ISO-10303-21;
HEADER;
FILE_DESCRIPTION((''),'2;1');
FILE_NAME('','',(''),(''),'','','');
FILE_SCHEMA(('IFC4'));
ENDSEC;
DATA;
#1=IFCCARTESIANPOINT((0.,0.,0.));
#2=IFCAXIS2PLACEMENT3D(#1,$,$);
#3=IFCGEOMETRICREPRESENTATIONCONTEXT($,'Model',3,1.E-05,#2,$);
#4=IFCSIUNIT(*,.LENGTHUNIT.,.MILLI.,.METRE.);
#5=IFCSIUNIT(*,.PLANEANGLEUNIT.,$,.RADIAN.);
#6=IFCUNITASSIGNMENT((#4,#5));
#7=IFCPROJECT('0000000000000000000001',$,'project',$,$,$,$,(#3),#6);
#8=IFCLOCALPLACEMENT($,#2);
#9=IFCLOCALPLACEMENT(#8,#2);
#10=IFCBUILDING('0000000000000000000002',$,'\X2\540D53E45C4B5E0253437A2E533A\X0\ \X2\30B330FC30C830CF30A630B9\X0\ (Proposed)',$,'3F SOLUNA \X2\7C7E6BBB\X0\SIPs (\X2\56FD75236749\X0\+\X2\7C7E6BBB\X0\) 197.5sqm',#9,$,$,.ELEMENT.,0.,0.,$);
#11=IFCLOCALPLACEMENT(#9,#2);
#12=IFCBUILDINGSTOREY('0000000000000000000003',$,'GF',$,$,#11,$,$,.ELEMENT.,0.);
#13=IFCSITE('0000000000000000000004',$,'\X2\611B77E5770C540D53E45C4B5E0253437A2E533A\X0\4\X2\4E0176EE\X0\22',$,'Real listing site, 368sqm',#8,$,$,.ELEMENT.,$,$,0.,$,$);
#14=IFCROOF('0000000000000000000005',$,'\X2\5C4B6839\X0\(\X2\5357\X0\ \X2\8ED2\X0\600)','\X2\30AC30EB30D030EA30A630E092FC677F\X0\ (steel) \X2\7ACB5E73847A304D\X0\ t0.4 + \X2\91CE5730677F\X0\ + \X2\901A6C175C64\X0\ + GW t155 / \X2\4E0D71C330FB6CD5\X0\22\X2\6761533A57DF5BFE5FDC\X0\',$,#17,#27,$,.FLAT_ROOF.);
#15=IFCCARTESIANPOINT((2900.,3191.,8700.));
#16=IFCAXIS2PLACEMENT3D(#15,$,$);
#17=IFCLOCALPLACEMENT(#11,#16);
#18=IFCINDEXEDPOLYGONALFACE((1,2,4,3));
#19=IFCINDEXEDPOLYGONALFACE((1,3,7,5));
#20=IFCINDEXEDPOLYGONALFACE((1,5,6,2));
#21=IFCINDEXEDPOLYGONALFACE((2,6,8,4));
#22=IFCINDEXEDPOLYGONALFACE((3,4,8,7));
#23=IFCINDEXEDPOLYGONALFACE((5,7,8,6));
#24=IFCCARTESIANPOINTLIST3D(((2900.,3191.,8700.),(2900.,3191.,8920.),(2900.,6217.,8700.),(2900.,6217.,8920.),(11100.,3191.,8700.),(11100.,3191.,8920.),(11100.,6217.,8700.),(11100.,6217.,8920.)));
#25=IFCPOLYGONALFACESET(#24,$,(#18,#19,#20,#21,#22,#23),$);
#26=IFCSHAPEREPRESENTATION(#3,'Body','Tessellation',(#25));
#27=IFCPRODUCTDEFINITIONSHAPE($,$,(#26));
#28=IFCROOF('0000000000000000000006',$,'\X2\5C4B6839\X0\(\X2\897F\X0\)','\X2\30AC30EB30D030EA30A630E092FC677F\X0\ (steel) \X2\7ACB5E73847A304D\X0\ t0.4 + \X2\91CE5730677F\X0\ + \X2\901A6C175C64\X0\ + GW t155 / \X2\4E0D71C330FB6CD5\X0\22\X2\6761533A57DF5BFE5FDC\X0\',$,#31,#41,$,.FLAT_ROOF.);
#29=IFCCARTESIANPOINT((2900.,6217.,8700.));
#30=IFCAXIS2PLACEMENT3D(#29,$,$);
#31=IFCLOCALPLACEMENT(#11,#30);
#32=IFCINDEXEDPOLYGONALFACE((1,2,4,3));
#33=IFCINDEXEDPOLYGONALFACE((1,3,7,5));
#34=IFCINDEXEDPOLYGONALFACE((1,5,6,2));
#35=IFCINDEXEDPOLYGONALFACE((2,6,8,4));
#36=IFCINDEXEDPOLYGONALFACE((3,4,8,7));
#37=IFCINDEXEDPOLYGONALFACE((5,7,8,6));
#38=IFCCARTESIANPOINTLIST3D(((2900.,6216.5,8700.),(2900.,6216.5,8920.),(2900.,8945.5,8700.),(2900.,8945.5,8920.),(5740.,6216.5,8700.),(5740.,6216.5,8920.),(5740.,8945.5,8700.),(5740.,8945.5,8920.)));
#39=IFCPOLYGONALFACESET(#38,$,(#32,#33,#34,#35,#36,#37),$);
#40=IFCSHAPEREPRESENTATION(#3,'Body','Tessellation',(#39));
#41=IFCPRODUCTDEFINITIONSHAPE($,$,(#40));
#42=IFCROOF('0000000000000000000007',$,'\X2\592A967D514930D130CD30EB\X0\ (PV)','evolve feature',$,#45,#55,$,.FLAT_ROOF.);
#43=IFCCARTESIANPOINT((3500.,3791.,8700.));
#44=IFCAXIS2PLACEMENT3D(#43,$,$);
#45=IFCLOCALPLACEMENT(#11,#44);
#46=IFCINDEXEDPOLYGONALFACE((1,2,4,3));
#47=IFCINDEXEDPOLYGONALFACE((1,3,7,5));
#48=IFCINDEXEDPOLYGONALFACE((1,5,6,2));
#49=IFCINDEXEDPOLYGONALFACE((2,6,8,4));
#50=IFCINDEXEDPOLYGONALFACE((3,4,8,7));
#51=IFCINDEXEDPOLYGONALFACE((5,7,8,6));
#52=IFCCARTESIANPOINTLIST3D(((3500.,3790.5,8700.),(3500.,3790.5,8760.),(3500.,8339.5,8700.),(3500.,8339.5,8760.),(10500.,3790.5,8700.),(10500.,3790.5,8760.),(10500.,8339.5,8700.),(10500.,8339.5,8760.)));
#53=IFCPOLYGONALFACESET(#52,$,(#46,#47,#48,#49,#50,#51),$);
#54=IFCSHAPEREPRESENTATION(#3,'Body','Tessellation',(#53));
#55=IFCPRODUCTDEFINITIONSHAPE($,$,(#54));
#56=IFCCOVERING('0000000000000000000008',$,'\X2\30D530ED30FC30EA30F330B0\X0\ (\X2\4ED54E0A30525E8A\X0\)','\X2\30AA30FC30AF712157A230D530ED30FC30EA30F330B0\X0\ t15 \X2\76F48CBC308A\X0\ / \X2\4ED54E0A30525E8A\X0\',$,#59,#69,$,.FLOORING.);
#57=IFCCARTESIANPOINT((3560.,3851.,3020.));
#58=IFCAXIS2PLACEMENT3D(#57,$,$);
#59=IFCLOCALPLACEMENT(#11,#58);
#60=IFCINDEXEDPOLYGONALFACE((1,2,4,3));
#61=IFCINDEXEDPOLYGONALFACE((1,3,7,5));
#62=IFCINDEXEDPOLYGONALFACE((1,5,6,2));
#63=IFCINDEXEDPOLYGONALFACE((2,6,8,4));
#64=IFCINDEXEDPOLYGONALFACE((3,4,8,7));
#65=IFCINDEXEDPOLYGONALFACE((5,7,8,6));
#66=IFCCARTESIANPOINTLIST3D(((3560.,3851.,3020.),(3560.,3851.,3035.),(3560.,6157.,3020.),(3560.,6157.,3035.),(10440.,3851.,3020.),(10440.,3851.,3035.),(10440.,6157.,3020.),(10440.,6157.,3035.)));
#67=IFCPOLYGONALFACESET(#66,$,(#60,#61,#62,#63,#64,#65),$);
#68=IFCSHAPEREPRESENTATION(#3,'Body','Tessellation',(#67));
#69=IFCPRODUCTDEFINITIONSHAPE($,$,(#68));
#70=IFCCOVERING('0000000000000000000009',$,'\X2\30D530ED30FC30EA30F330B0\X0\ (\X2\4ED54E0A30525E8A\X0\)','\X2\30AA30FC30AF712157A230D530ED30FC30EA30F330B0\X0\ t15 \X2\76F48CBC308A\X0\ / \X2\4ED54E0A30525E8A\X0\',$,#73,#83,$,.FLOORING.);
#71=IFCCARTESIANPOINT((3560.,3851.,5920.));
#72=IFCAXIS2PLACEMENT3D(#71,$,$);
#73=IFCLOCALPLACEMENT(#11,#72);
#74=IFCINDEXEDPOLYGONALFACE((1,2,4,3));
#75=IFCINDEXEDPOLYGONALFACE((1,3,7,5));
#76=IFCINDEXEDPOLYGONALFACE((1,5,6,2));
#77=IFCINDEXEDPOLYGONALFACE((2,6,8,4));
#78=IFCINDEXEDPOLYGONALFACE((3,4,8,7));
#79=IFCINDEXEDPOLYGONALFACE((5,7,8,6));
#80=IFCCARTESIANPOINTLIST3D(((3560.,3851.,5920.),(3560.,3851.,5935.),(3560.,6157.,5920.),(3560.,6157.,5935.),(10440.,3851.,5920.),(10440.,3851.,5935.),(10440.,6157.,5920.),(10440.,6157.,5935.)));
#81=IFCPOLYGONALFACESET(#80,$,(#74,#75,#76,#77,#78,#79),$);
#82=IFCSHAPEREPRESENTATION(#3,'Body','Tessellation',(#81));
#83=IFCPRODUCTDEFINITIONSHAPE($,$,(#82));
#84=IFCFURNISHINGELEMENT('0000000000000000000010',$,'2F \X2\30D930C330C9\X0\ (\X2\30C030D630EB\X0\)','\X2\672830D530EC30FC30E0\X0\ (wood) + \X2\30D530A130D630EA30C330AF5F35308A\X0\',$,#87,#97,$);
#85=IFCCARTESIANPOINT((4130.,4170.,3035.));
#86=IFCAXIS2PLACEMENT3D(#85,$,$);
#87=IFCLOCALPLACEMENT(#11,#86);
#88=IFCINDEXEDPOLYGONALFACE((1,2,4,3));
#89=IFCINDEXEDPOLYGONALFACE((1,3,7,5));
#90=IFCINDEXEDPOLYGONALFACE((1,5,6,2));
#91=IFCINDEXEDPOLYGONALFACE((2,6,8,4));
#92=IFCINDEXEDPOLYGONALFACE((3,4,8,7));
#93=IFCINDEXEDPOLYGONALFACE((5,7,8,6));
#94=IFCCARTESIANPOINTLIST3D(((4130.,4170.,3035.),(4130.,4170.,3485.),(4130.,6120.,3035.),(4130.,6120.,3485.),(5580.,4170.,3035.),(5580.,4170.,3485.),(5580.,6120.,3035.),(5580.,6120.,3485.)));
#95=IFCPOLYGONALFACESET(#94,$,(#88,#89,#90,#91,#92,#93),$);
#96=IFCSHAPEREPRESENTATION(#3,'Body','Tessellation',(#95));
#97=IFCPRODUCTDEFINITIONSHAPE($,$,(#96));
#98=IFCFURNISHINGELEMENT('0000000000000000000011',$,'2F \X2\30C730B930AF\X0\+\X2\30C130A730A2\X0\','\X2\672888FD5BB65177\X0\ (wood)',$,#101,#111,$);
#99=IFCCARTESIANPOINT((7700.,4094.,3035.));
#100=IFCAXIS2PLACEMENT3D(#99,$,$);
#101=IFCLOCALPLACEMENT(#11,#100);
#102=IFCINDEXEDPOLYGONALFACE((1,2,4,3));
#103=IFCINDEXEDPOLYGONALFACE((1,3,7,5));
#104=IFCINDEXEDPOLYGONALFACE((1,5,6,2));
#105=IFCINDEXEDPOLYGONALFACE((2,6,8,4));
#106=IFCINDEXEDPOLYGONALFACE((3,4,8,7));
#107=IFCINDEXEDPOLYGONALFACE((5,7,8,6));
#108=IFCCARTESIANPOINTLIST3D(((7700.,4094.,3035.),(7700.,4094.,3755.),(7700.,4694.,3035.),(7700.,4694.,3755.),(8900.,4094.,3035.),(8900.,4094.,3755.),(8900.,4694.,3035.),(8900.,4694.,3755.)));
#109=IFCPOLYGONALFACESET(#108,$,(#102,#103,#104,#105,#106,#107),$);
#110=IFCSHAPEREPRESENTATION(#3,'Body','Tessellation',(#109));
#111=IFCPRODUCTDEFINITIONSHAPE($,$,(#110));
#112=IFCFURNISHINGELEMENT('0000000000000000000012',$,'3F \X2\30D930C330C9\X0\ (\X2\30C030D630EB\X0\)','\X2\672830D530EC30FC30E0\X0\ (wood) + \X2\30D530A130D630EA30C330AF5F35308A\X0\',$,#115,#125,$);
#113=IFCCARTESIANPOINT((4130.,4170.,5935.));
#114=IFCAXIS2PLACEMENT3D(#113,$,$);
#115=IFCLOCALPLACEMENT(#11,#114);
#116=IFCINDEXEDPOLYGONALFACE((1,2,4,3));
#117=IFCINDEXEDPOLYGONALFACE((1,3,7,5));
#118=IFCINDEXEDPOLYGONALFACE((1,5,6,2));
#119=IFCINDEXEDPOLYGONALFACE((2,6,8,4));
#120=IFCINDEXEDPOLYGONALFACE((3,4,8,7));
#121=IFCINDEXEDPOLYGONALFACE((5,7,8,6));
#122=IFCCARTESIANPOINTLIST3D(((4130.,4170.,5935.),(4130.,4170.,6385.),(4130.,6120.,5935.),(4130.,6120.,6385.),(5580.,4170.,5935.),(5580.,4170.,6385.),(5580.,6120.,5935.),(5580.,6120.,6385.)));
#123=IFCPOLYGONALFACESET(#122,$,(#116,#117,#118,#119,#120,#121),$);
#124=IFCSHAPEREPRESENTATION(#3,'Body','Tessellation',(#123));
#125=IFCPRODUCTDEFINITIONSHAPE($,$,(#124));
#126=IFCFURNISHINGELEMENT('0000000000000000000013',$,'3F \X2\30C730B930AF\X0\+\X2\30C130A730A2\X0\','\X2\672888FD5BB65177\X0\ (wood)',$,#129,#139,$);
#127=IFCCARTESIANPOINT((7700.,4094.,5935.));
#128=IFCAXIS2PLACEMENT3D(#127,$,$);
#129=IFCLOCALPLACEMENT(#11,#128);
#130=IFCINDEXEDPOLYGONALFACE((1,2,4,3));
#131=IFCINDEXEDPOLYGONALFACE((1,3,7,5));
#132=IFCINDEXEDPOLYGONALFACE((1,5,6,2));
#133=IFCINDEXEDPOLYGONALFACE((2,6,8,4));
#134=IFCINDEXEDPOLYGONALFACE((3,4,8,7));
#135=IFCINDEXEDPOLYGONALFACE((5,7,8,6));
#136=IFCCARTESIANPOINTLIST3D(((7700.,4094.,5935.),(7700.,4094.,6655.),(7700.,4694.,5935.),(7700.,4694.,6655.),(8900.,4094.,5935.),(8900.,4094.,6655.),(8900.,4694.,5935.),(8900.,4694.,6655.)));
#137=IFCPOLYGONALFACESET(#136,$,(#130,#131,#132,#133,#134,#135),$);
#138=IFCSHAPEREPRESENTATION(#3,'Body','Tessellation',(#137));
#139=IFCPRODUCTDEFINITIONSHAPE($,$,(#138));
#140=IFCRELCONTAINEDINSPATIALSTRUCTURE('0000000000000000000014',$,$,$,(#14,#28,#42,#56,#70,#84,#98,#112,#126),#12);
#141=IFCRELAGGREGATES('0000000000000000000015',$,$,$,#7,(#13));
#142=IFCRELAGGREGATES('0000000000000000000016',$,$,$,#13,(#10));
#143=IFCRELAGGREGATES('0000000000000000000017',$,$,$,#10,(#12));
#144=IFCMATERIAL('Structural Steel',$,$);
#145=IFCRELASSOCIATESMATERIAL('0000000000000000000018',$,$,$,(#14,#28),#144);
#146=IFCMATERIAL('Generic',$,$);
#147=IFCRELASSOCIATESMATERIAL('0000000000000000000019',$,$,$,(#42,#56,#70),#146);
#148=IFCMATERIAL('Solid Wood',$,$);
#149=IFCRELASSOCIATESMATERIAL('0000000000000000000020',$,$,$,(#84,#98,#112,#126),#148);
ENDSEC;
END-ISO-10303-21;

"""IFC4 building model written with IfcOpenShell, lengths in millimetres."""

from ifc_helpers import new_model, si_unit, frame, frame_2d, origin, place, context, project, spatial, rectangle, extrude, material, element, save


model = new_model("IFC4")

# Units and contexts
model_context = context("Model", 3, precision=1e-05, world=origin())
ifc_project = project(units=[si_unit("LENGTHUNIT", "METRE", prefix="MILLI"), si_unit("PLANEANGLEUNIT", "RADIAN")], contexts=[model_context])

# Site, building, storey
site_placement = place(None, origin())
site = spatial("IfcSite", under=ifc_project, at=site_placement, Name="愛知県名古屋市千種区4丁目22", ObjectType="Real listing site, 368sqm", CompositionType="ELEMENT", RefElevation=0.0)
building_placement = place(site_placement, origin())
building = spatial("IfcBuilding", under=site, at=building_placement, Name="名古屋市千種区 コートハウス (Proposed)", ObjectType="3F SOLUNA 籾殻SIPs (国産杉+籾殻) 197.5sqm", CompositionType="ELEMENT", ElevationOfRefHeight=0.0, ElevationOfTerrain=0.0)
storey_placement = place(building_placement, origin())
storey = spatial("IfcBuildingStorey", under=building, at=storey_placement, Name="GF", CompositionType="ELEMENT", Elevation=0.0)

# Shared definitions
ifc_material_1 = material(Name="Solid Wood")

# Roofs
ifc_material_2 = material(Name="Structural Steel")
roof_1_placement = place(storey_placement, frame((2900.0, 3191.0, 8700.0)))
element("IfcRoof", 1, at=roof_1_placement, inside=storey, material=ifc_material_2, Name="屋根(南 軒600)", Description="ガルバリウム鋼板 (steel) 立平葺き t0.4 + 野地板 + 通気層 + GW t155 / 不燃・法22条区域対応", PredefinedType="FLAT_ROOF", context=model_context, shape_type="SweptSolid", body=[
    extrude(rectangle(XDim=8200.0, YDim=3026.0, at=frame_2d((4100.0, 1513.0))), frame((2900.0, 3191.0, 8700.0)), (0.0, 0.0, 1.0), 220.0),
])
roof_2_placement = place(storey_placement, frame((2900.0, 6217.0, 8700.0)))
element("IfcRoof", 2, at=roof_2_placement, inside=storey, material=ifc_material_2, Name="屋根(西)", Description="ガルバリウム鋼板 (steel) 立平葺き t0.4 + 野地板 + 通気層 + GW t155 / 不燃・法22条区域対応", PredefinedType="FLAT_ROOF", context=model_context, shape_type="SweptSolid", body=[
    extrude(rectangle(XDim=2840.0, YDim=2729.0, at=frame_2d((1420.0, 1364.0))), frame((2900.0, 6217.0, 8700.0)), (0.0, 0.0, 1.0), 220.0),
])
ifc_material_3 = material(Name="Generic")
roof_3_placement = place(storey_placement, frame((3500.0, 3791.0, 8700.0)))
element("IfcRoof", 3, at=roof_3_placement, inside=storey, material=ifc_material_3, Name="太陽光パネル (PV)", Description="evolve feature", PredefinedType="FLAT_ROOF", context=model_context, shape_type="SweptSolid", body=[
    extrude(rectangle(XDim=7000.0, YDim=4549.0, at=frame_2d((3500.0, 2274.0))), frame((3500.0, 3791.0, 8700.0)), (0.0, 0.0, 1.0), 60.0),
])

# Coverings
covering_1_placement = place(storey_placement, frame((3560.0, 3851.0, 3020.0)))
element("IfcCovering", 4, at=covering_1_placement, inside=storey, material=ifc_material_3, Name="フローリング (仕上げ床)", Description="オーク無垢フローリング t15 直貼り / 仕上げ床", PredefinedType="FLOORING", context=model_context, shape_type="SweptSolid", body=[
    extrude(rectangle(XDim=6880.0, YDim=2306.0, at=frame_2d((3440.0, 1153.0))), frame((3560.0, 3851.0, 3020.0)), (0.0, 0.0, 1.0), 15.0),
])
covering_2_placement = place(storey_placement, frame((3560.0, 3851.0, 5920.0)))
element("IfcCovering", 5, at=covering_2_placement, inside=storey, material=ifc_material_3, Name="フローリング (仕上げ床)", Description="オーク無垢フローリング t15 直貼り / 仕上げ床", PredefinedType="FLOORING", context=model_context, shape_type="SweptSolid", body=[
    extrude(rectangle(XDim=6880.0, YDim=2306.0, at=frame_2d((3440.0, 1153.0))), frame((3560.0, 3851.0, 5920.0)), (0.0, 0.0, 1.0), 15.0),
])

# Furnishing elements
furnishing_1_placement = place(storey_placement, frame((4130.0, 4170.0, 3035.0)))
element("IfcFurnishingElement", 6, at=furnishing_1_placement, inside=storey, material=ifc_material_1, Name="2F ベッド (ダブル)", Description="木フレーム (wood) + ファブリック張り", context=model_context, shape_type="SweptSolid", body=[
    extrude(rectangle(XDim=1450.0, YDim=1950.0, at=frame_2d((725.0, 975.0))), frame((4130.0, 4170.0, 3035.0)), (0.0, 0.0, 1.0), 450.0),
])
furnishing_2_placement = place(storey_placement, frame((7700.0, 4094.0, 3035.0)))
element("IfcFurnishingElement", 7, at=furnishing_2_placement, inside=storey, material=ifc_material_1, Name="2F デスク+チェア", Description="木製家具 (wood)", context=model_context, shape_type="SweptSolid", body=[
    extrude(rectangle(XDim=1200.0, YDim=600.0, at=frame_2d((600.0, 300.0))), frame((7700.0, 4094.0, 3035.0)), (0.0, 0.0, 1.0), 720.0),
])
furnishing_3_placement = place(storey_placement, frame((4130.0, 4170.0, 5935.0)))
element("IfcFurnishingElement", 8, at=furnishing_3_placement, inside=storey, material=ifc_material_1, Name="3F ベッド (ダブル)", Description="木フレーム (wood) + ファブリック張り", context=model_context, shape_type="SweptSolid", body=[
    extrude(rectangle(XDim=1450.0, YDim=1950.0, at=frame_2d((725.0, 975.0))), frame((4130.0, 4170.0, 5935.0)), (0.0, 0.0, 1.0), 450.0),
])
furnishing_4_placement = place(storey_placement, frame((7700.0, 4094.0, 5935.0)))
element("IfcFurnishingElement", 9, at=furnishing_4_placement, inside=storey, material=ifc_material_1, Name="3F デスク+チェア", Description="木製家具 (wood)", context=model_context, shape_type="SweptSolid", body=[
    extrude(rectangle(XDim=1200.0, YDim=600.0, at=frame_2d((600.0, 300.0))), frame((7700.0, 4094.0, 5935.0)), (0.0, 0.0, 1.0), 720.0),
])

save(model, "model.ifc")
